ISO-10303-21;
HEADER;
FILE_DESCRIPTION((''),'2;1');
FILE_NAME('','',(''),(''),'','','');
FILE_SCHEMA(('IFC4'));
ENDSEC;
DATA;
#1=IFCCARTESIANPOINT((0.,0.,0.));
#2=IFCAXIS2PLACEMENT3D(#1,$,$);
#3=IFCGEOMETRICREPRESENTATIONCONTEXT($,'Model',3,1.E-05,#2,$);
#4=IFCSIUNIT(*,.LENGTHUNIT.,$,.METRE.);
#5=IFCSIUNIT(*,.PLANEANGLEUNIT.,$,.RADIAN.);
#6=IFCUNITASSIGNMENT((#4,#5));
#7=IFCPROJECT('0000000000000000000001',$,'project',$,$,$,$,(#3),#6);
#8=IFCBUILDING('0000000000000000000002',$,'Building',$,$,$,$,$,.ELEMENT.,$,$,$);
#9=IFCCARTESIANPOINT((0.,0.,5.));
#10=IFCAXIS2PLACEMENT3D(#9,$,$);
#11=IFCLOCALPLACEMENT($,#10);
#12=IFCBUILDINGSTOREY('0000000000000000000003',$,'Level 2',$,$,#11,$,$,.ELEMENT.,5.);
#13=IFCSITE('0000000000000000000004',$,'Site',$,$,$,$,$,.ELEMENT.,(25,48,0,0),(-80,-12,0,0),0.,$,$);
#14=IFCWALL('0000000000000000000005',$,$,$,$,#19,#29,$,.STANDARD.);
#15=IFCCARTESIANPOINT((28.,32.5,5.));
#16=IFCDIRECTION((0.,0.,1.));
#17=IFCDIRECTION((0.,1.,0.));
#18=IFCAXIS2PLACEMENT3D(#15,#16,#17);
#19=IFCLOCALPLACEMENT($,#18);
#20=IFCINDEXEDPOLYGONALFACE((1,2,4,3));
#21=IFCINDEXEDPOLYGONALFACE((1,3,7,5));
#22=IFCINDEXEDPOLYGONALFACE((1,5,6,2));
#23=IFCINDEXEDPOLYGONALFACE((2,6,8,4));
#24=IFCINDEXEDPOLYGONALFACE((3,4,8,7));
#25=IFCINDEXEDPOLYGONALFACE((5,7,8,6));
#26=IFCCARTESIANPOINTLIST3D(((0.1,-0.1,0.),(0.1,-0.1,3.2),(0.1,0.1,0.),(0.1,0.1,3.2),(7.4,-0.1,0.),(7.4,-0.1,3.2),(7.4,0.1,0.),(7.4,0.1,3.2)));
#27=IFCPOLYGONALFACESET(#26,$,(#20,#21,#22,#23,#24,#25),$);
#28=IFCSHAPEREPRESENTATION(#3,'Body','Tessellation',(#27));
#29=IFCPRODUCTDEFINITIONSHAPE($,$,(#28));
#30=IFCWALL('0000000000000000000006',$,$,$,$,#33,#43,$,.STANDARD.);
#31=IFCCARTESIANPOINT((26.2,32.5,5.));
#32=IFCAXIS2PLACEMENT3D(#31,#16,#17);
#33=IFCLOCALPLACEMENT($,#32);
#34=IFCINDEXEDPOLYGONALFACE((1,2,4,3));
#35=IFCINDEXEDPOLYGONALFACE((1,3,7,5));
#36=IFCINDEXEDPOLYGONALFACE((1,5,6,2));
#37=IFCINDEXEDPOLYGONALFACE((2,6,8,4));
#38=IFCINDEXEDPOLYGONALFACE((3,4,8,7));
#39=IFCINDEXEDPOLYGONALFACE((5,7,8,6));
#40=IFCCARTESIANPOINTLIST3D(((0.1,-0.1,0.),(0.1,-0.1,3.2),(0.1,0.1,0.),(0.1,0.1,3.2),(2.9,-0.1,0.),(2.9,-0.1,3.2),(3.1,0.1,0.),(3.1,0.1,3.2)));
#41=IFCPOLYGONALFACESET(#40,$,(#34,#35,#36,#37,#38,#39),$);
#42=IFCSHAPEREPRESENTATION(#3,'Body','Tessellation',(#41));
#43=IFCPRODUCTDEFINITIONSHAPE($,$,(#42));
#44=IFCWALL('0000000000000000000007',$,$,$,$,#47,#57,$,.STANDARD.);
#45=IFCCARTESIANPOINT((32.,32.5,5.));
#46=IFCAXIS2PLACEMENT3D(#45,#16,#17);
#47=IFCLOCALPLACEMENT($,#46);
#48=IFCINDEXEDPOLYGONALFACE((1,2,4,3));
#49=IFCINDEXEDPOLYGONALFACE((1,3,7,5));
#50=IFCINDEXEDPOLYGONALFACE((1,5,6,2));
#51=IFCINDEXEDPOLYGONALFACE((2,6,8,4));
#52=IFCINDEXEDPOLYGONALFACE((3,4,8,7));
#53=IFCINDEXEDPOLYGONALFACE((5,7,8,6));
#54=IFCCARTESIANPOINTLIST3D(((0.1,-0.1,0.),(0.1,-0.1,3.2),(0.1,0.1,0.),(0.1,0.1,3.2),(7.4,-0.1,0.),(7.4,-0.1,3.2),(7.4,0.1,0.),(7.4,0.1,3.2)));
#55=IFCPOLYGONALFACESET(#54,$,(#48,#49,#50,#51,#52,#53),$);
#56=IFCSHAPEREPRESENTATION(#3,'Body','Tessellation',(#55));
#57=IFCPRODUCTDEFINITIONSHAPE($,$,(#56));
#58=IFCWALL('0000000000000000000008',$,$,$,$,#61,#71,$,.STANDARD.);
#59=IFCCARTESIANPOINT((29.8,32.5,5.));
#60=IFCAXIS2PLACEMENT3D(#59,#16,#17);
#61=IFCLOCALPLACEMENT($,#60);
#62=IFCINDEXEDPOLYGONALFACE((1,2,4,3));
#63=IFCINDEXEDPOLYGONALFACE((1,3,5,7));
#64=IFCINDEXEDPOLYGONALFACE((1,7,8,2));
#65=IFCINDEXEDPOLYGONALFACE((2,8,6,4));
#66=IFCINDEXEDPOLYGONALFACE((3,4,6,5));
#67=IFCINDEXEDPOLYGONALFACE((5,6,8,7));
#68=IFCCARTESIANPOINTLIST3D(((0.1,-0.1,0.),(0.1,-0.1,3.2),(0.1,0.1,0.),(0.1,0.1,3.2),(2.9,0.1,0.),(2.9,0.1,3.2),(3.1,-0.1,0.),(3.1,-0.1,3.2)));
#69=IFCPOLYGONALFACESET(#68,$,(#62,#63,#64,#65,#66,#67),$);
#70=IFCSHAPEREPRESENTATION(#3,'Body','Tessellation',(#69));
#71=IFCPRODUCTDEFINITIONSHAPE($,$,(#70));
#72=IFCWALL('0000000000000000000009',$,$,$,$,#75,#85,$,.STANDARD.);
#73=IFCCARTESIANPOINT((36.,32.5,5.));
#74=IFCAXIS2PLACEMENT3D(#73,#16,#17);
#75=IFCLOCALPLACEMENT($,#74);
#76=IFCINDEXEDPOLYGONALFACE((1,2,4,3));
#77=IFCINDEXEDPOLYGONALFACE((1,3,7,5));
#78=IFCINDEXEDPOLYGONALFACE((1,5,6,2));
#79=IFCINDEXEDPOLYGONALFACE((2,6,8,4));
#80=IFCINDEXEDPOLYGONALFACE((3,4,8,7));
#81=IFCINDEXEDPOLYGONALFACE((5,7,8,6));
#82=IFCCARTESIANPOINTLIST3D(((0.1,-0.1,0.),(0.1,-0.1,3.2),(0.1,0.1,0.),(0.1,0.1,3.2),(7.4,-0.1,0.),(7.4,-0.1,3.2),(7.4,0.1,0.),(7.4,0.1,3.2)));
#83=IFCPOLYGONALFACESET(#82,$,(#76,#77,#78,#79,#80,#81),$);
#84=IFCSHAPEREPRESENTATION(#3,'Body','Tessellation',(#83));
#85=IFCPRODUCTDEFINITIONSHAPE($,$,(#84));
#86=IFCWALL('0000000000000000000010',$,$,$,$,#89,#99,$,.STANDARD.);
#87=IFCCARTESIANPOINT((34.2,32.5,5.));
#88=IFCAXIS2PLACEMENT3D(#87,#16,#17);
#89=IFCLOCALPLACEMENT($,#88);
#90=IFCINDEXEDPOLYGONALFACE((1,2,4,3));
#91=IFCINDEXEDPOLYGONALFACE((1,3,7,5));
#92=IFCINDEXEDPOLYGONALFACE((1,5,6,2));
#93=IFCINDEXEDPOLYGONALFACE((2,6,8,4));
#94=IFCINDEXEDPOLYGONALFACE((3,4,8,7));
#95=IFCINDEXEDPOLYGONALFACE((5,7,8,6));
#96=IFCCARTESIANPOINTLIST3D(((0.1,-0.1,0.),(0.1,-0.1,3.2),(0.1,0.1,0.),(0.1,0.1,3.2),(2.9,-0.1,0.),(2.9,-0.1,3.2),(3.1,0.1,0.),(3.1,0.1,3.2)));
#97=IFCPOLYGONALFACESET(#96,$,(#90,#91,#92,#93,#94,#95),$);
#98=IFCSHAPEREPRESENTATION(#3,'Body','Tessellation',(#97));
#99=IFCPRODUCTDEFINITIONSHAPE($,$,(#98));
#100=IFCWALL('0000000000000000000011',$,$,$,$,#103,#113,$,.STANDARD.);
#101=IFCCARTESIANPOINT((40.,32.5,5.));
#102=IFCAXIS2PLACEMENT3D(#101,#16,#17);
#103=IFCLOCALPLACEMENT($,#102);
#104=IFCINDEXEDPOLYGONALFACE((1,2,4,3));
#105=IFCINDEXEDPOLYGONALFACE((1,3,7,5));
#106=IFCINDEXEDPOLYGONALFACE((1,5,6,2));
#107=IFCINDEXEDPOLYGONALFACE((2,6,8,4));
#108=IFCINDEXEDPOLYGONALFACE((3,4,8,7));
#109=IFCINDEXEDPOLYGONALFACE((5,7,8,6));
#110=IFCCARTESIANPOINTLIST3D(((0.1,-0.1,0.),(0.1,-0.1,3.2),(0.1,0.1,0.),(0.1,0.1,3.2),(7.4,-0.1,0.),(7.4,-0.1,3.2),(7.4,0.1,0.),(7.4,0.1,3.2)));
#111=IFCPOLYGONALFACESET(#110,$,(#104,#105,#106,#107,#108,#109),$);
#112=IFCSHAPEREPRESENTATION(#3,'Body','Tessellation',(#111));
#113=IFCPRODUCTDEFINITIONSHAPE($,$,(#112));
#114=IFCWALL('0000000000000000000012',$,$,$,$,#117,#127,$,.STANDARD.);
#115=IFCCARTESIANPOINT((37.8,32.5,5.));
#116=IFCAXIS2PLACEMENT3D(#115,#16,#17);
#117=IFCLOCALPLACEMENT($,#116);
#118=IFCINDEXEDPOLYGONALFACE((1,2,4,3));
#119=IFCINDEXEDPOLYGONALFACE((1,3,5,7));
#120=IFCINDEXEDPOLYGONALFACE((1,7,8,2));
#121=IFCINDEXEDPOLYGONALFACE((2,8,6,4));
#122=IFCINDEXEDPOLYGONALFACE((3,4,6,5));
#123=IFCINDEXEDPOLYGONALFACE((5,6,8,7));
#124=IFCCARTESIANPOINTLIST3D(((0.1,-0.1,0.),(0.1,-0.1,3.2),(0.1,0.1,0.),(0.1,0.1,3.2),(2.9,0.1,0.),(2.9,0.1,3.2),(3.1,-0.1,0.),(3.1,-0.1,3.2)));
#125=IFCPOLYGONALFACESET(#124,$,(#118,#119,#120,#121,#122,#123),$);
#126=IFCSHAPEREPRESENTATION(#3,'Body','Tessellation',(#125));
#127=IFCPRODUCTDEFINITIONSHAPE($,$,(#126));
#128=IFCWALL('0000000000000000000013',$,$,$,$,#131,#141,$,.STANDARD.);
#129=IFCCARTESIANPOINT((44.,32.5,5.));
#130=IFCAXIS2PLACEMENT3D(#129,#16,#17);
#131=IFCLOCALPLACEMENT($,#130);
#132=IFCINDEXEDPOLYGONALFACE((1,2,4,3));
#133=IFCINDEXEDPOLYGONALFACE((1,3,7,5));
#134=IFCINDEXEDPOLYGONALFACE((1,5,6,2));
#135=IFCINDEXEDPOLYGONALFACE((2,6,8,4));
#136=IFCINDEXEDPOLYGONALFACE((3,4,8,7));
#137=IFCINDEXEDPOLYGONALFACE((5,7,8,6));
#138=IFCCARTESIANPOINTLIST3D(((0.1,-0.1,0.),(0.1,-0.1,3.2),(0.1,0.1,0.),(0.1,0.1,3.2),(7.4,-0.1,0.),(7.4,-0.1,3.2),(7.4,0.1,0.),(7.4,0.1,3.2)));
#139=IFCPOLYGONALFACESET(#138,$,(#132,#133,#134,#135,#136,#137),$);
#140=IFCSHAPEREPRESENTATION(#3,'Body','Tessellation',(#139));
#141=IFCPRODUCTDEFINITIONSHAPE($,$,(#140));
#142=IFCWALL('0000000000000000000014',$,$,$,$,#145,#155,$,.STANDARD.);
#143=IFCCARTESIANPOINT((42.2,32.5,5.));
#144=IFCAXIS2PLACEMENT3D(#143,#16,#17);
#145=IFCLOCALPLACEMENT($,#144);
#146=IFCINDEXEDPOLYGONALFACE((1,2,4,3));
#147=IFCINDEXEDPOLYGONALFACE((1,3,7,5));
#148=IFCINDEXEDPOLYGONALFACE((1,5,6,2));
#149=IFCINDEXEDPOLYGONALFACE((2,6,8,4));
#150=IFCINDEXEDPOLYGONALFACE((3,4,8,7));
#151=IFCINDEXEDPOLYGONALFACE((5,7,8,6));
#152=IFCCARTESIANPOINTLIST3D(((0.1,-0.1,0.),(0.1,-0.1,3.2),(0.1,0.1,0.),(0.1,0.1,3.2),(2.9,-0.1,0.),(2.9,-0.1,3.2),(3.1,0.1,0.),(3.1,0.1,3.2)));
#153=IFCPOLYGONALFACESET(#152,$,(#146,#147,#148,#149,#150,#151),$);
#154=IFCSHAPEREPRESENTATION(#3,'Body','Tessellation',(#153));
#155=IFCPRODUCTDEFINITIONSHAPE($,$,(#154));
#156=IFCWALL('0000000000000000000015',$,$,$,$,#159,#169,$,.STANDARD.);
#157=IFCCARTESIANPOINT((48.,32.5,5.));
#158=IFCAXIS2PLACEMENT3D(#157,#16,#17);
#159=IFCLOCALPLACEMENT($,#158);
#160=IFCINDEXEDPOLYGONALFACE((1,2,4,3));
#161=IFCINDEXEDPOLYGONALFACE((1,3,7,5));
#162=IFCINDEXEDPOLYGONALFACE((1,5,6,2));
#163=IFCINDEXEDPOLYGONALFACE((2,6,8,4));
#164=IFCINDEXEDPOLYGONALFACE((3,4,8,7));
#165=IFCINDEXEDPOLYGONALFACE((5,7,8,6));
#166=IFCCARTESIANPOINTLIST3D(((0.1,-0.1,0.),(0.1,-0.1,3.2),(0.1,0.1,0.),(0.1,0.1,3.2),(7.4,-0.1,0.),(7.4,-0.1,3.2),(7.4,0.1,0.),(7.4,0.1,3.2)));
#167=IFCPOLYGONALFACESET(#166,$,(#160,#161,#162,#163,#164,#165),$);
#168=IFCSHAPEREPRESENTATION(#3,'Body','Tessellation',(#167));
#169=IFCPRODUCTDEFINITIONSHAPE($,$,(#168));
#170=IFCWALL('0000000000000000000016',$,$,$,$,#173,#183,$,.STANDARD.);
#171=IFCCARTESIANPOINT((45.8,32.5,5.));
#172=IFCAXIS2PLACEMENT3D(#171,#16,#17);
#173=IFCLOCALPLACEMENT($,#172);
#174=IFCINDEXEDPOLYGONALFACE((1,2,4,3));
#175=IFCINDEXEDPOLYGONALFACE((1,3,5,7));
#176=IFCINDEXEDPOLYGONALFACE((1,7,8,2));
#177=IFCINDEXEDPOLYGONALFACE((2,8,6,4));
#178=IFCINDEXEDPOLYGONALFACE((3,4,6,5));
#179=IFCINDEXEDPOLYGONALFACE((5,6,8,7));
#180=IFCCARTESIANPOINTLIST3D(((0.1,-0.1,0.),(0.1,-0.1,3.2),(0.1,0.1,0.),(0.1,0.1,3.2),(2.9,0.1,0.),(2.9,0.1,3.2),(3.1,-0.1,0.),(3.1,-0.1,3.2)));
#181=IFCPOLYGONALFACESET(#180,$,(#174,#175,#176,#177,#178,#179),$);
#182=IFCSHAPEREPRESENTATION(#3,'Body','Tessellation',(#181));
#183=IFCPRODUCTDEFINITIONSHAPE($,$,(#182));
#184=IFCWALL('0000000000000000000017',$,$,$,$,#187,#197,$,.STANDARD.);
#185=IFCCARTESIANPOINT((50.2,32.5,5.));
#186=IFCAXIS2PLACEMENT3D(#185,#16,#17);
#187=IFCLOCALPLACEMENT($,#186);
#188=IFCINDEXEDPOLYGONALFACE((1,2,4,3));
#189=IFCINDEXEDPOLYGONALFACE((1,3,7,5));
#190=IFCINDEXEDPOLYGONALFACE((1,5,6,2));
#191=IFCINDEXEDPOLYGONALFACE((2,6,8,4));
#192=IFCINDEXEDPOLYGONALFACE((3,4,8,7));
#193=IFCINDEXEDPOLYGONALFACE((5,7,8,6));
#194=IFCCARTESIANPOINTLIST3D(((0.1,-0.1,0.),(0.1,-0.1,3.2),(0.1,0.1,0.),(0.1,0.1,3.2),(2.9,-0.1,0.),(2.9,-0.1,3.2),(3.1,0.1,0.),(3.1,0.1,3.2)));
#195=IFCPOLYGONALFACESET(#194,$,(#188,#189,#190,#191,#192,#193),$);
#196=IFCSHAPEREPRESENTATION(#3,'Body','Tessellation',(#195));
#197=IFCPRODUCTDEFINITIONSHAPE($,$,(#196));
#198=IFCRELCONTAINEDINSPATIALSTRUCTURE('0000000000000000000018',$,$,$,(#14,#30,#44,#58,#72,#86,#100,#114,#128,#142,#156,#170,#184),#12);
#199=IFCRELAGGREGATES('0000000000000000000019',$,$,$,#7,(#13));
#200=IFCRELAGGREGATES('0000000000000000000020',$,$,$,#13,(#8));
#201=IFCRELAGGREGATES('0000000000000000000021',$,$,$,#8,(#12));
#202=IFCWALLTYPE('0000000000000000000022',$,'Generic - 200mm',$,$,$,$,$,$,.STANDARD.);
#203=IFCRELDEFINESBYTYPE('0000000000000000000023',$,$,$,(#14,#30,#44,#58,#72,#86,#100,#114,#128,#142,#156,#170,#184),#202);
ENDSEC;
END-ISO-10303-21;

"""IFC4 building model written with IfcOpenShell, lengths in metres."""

from ifc_helpers import new_model, si_unit, frame, origin, place, context, project, spatial, polyline, outline, extrude, type_object, element, save


model = new_model("IFC4")

# Units and contexts
model_context = context("Model", 3, precision=1e-05, world=origin())
ifc_project = project(units=[si_unit("LENGTHUNIT", "METRE"), si_unit("PLANEANGLEUNIT", "RADIAN")], contexts=[model_context])

# Site, building, storey
site = spatial("IfcSite", under=ifc_project, Name="Site", CompositionType="ELEMENT", RefLatitude=(25, 48, 0, 0), RefLongitude=(-80, -12, 0, 0), RefElevation=0.0)
building = spatial("IfcBuilding", under=site, Name="Building", CompositionType="ELEMENT")
storey_placement = place(None, frame((0.0, 0.0, 5.0)))
storey = spatial("IfcBuildingStorey", under=building, at=storey_placement, Name="Level 2", CompositionType="ELEMENT", Elevation=5.0)

# Shared definitions
wall_type = type_object("IfcWallType", Name="Generic - 200mm", PredefinedType="STANDARD")

# Walls
wall_1_placement = place(None, frame((28.0, 32.5, 5.0), z_axis=(0.0, 0.0, 1.0), x_axis=(0.0, 1.0, 0.0)))
element("IfcWall", 1, at=wall_1_placement, inside=storey, type_object=wall_type, PredefinedType="STANDARD", context=model_context, shape_type="SweptSolid", body=[
    extrude(outline(polyline([(0.1, -0.1), (7.4, -0.1), (7.4, 0.1), (0.1, 0.1), (0.1, -0.1)])), origin(), (0.0, 0.0, 1.0), 3.2),
])
wall_2_placement = place(None, frame((26.2, 32.5, 5.0), z_axis=(0.0, 0.0, 1.0), x_axis=(0.0, 1.0, 0.0)))
element("IfcWall", 2, at=wall_2_placement, inside=storey, type_object=wall_type, PredefinedType="STANDARD", context=model_context, shape_type="SweptSolid", body=[
    extrude(outline(polyline([(0.1, -0.1), (2.9, -0.1), (3.1, 0.1), (0.1, 0.1), (0.1, -0.1)])), origin(), (0.0, 0.0, 1.0), 3.2),
])
wall_3_placement = place(None, frame((32.0, 32.5, 5.0), z_axis=(0.0, 0.0, 1.0), x_axis=(0.0, 1.0, 0.0)))
element("IfcWall", 3, at=wall_3_placement, inside=storey, type_object=wall_type, PredefinedType="STANDARD", context=model_context, shape_type="SweptSolid", body=[
    extrude(outline(polyline([(0.1, -0.1), (7.4, -0.1), (7.4, 0.1), (0.1, 0.1), (0.1, -0.1)])), origin(), (0.0, 0.0, 1.0), 3.2),
])
wall_4_placement = place(None, frame((29.8, 32.5, 5.0), z_axis=(0.0, 0.0, 1.0), x_axis=(0.0, 1.0, 0.0)))
element("IfcWall", 4, at=wall_4_placement, inside=storey, type_object=wall_type, PredefinedType="STANDARD", context=model_context, shape_type="SweptSolid", body=[
    extrude(outline(polyline([(0.1, -0.1), (3.1, -0.1), (2.9, 0.1), (0.1, 0.1), (0.1, -0.1)])), origin(), (0.0, 0.0, 1.0), 3.2),
])
wall_5_placement = place(None, frame((36.0, 32.5, 5.0), z_axis=(0.0, 0.0, 1.0), x_axis=(0.0, 1.0, 0.0)))
element("IfcWall", 5, at=wall_5_placement, inside=storey, type_object=wall_type, PredefinedType="STANDARD", context=model_context, shape_type="SweptSolid", body=[
    extrude(outline(polyline([(0.1, -0.1), (7.4, -0.1), (7.4, 0.1), (0.1, 0.1), (0.1, -0.1)])), origin(), (0.0, 0.0, 1.0), 3.2),
])
wall_6_placement = place(None, frame((34.2, 32.5, 5.0), z_axis=(0.0, 0.0, 1.0), x_axis=(0.0, 1.0, 0.0)))
element("IfcWall", 6, at=wall_6_placement, inside=storey, type_object=wall_type, PredefinedType="STANDARD", context=model_context, shape_type="SweptSolid", body=[
    extrude(outline(polyline([(0.1, -0.1), (2.9, -0.1), (3.1, 0.1), (0.1, 0.1), (0.1, -0.1)])), origin(), (0.0, 0.0, 1.0), 3.2),
])
wall_7_placement = place(None, frame((40.0, 32.5, 5.0), z_axis=(0.0, 0.0, 1.0), x_axis=(0.0, 1.0, 0.0)))
element("IfcWall", 7, at=wall_7_placement, inside=storey, type_object=wall_type, PredefinedType="STANDARD", context=model_context, shape_type="SweptSolid", body=[
    extrude(outline(polyline([(0.1, -0.1), (7.4, -0.1), (7.4, 0.1), (0.1, 0.1), (0.1, -0.1)])), origin(), (0.0, 0.0, 1.0), 3.2),
])
wall_8_placement = place(None, frame((37.8, 32.5, 5.0), z_axis=(0.0, 0.0, 1.0), x_axis=(0.0, 1.0, 0.0)))
element("IfcWall", 8, at=wall_8_placement, inside=storey, type_object=wall_type, PredefinedType="STANDARD", context=model_context, shape_type="SweptSolid", body=[
    extrude(outline(polyline([(0.1, -0.1), (3.1, -0.1), (2.9, 0.1), (0.1, 0.1), (0.1, -0.1)])), origin(), (0.0, 0.0, 1.0), 3.2),
])
wall_9_placement = place(None, frame((44.0, 32.5, 5.0), z_axis=(0.0, 0.0, 1.0), x_axis=(0.0, 1.0, 0.0)))
element("IfcWall", 9, at=wall_9_placement, inside=storey, type_object=wall_type, PredefinedType="STANDARD", context=model_context, shape_type="SweptSolid", body=[
    extrude(outline(polyline([(0.1, -0.1), (7.4, -0.1), (7.4, 0.1), (0.1, 0.1), (0.1, -0.1)])), origin(), (0.0, 0.0, 1.0), 3.2),
])
wall_10_placement = place(None, frame((42.2, 32.5, 5.0), z_axis=(0.0, 0.0, 1.0), x_axis=(0.0, 1.0, 0.0)))
element("IfcWall", 10, at=wall_10_placement, inside=storey, type_object=wall_type, PredefinedType="STANDARD", context=model_context, shape_type="SweptSolid", body=[
    extrude(outline(polyline([(0.1, -0.1), (2.9, -0.1), (3.1, 0.1), (0.1, 0.1), (0.1, -0.1)])), origin(), (0.0, 0.0, 1.0), 3.2),
])
wall_11_placement = place(None, frame((48.0, 32.5, 5.0), z_axis=(0.0, 0.0, 1.0), x_axis=(0.0, 1.0, 0.0)))
element("IfcWall", 11, at=wall_11_placement, inside=storey, type_object=wall_type, PredefinedType="STANDARD", context=model_context, shape_type="SweptSolid", body=[
    extrude(outline(polyline([(0.1, -0.1), (7.4, -0.1), (7.4, 0.1), (0.1, 0.1), (0.1, -0.1)])), origin(), (0.0, 0.0, 1.0), 3.2),
])
wall_12_placement = place(None, frame((45.8, 32.5, 5.0), z_axis=(0.0, 0.0, 1.0), x_axis=(0.0, 1.0, 0.0)))
element("IfcWall", 12, at=wall_12_placement, inside=storey, type_object=wall_type, PredefinedType="STANDARD", context=model_context, shape_type="SweptSolid", body=[
    extrude(outline(polyline([(0.1, -0.1), (3.1, -0.1), (2.9, 0.1), (0.1, 0.1), (0.1, -0.1)])), origin(), (0.0, 0.0, 1.0), 3.2),
])
wall_13_placement = place(None, frame((50.2, 32.5, 5.0), z_axis=(0.0, 0.0, 1.0), x_axis=(0.0, 1.0, 0.0)))
element("IfcWall", 13, at=wall_13_placement, inside=storey, type_object=wall_type, PredefinedType="STANDARD", context=model_context, shape_type="SweptSolid", body=[
    extrude(outline(polyline([(0.1, -0.1), (2.9, -0.1), (3.1, 0.1), (0.1, 0.1), (0.1, -0.1)])), origin(), (0.0, 0.0, 1.0), 3.2),
])

save(model, "model.ifc")
